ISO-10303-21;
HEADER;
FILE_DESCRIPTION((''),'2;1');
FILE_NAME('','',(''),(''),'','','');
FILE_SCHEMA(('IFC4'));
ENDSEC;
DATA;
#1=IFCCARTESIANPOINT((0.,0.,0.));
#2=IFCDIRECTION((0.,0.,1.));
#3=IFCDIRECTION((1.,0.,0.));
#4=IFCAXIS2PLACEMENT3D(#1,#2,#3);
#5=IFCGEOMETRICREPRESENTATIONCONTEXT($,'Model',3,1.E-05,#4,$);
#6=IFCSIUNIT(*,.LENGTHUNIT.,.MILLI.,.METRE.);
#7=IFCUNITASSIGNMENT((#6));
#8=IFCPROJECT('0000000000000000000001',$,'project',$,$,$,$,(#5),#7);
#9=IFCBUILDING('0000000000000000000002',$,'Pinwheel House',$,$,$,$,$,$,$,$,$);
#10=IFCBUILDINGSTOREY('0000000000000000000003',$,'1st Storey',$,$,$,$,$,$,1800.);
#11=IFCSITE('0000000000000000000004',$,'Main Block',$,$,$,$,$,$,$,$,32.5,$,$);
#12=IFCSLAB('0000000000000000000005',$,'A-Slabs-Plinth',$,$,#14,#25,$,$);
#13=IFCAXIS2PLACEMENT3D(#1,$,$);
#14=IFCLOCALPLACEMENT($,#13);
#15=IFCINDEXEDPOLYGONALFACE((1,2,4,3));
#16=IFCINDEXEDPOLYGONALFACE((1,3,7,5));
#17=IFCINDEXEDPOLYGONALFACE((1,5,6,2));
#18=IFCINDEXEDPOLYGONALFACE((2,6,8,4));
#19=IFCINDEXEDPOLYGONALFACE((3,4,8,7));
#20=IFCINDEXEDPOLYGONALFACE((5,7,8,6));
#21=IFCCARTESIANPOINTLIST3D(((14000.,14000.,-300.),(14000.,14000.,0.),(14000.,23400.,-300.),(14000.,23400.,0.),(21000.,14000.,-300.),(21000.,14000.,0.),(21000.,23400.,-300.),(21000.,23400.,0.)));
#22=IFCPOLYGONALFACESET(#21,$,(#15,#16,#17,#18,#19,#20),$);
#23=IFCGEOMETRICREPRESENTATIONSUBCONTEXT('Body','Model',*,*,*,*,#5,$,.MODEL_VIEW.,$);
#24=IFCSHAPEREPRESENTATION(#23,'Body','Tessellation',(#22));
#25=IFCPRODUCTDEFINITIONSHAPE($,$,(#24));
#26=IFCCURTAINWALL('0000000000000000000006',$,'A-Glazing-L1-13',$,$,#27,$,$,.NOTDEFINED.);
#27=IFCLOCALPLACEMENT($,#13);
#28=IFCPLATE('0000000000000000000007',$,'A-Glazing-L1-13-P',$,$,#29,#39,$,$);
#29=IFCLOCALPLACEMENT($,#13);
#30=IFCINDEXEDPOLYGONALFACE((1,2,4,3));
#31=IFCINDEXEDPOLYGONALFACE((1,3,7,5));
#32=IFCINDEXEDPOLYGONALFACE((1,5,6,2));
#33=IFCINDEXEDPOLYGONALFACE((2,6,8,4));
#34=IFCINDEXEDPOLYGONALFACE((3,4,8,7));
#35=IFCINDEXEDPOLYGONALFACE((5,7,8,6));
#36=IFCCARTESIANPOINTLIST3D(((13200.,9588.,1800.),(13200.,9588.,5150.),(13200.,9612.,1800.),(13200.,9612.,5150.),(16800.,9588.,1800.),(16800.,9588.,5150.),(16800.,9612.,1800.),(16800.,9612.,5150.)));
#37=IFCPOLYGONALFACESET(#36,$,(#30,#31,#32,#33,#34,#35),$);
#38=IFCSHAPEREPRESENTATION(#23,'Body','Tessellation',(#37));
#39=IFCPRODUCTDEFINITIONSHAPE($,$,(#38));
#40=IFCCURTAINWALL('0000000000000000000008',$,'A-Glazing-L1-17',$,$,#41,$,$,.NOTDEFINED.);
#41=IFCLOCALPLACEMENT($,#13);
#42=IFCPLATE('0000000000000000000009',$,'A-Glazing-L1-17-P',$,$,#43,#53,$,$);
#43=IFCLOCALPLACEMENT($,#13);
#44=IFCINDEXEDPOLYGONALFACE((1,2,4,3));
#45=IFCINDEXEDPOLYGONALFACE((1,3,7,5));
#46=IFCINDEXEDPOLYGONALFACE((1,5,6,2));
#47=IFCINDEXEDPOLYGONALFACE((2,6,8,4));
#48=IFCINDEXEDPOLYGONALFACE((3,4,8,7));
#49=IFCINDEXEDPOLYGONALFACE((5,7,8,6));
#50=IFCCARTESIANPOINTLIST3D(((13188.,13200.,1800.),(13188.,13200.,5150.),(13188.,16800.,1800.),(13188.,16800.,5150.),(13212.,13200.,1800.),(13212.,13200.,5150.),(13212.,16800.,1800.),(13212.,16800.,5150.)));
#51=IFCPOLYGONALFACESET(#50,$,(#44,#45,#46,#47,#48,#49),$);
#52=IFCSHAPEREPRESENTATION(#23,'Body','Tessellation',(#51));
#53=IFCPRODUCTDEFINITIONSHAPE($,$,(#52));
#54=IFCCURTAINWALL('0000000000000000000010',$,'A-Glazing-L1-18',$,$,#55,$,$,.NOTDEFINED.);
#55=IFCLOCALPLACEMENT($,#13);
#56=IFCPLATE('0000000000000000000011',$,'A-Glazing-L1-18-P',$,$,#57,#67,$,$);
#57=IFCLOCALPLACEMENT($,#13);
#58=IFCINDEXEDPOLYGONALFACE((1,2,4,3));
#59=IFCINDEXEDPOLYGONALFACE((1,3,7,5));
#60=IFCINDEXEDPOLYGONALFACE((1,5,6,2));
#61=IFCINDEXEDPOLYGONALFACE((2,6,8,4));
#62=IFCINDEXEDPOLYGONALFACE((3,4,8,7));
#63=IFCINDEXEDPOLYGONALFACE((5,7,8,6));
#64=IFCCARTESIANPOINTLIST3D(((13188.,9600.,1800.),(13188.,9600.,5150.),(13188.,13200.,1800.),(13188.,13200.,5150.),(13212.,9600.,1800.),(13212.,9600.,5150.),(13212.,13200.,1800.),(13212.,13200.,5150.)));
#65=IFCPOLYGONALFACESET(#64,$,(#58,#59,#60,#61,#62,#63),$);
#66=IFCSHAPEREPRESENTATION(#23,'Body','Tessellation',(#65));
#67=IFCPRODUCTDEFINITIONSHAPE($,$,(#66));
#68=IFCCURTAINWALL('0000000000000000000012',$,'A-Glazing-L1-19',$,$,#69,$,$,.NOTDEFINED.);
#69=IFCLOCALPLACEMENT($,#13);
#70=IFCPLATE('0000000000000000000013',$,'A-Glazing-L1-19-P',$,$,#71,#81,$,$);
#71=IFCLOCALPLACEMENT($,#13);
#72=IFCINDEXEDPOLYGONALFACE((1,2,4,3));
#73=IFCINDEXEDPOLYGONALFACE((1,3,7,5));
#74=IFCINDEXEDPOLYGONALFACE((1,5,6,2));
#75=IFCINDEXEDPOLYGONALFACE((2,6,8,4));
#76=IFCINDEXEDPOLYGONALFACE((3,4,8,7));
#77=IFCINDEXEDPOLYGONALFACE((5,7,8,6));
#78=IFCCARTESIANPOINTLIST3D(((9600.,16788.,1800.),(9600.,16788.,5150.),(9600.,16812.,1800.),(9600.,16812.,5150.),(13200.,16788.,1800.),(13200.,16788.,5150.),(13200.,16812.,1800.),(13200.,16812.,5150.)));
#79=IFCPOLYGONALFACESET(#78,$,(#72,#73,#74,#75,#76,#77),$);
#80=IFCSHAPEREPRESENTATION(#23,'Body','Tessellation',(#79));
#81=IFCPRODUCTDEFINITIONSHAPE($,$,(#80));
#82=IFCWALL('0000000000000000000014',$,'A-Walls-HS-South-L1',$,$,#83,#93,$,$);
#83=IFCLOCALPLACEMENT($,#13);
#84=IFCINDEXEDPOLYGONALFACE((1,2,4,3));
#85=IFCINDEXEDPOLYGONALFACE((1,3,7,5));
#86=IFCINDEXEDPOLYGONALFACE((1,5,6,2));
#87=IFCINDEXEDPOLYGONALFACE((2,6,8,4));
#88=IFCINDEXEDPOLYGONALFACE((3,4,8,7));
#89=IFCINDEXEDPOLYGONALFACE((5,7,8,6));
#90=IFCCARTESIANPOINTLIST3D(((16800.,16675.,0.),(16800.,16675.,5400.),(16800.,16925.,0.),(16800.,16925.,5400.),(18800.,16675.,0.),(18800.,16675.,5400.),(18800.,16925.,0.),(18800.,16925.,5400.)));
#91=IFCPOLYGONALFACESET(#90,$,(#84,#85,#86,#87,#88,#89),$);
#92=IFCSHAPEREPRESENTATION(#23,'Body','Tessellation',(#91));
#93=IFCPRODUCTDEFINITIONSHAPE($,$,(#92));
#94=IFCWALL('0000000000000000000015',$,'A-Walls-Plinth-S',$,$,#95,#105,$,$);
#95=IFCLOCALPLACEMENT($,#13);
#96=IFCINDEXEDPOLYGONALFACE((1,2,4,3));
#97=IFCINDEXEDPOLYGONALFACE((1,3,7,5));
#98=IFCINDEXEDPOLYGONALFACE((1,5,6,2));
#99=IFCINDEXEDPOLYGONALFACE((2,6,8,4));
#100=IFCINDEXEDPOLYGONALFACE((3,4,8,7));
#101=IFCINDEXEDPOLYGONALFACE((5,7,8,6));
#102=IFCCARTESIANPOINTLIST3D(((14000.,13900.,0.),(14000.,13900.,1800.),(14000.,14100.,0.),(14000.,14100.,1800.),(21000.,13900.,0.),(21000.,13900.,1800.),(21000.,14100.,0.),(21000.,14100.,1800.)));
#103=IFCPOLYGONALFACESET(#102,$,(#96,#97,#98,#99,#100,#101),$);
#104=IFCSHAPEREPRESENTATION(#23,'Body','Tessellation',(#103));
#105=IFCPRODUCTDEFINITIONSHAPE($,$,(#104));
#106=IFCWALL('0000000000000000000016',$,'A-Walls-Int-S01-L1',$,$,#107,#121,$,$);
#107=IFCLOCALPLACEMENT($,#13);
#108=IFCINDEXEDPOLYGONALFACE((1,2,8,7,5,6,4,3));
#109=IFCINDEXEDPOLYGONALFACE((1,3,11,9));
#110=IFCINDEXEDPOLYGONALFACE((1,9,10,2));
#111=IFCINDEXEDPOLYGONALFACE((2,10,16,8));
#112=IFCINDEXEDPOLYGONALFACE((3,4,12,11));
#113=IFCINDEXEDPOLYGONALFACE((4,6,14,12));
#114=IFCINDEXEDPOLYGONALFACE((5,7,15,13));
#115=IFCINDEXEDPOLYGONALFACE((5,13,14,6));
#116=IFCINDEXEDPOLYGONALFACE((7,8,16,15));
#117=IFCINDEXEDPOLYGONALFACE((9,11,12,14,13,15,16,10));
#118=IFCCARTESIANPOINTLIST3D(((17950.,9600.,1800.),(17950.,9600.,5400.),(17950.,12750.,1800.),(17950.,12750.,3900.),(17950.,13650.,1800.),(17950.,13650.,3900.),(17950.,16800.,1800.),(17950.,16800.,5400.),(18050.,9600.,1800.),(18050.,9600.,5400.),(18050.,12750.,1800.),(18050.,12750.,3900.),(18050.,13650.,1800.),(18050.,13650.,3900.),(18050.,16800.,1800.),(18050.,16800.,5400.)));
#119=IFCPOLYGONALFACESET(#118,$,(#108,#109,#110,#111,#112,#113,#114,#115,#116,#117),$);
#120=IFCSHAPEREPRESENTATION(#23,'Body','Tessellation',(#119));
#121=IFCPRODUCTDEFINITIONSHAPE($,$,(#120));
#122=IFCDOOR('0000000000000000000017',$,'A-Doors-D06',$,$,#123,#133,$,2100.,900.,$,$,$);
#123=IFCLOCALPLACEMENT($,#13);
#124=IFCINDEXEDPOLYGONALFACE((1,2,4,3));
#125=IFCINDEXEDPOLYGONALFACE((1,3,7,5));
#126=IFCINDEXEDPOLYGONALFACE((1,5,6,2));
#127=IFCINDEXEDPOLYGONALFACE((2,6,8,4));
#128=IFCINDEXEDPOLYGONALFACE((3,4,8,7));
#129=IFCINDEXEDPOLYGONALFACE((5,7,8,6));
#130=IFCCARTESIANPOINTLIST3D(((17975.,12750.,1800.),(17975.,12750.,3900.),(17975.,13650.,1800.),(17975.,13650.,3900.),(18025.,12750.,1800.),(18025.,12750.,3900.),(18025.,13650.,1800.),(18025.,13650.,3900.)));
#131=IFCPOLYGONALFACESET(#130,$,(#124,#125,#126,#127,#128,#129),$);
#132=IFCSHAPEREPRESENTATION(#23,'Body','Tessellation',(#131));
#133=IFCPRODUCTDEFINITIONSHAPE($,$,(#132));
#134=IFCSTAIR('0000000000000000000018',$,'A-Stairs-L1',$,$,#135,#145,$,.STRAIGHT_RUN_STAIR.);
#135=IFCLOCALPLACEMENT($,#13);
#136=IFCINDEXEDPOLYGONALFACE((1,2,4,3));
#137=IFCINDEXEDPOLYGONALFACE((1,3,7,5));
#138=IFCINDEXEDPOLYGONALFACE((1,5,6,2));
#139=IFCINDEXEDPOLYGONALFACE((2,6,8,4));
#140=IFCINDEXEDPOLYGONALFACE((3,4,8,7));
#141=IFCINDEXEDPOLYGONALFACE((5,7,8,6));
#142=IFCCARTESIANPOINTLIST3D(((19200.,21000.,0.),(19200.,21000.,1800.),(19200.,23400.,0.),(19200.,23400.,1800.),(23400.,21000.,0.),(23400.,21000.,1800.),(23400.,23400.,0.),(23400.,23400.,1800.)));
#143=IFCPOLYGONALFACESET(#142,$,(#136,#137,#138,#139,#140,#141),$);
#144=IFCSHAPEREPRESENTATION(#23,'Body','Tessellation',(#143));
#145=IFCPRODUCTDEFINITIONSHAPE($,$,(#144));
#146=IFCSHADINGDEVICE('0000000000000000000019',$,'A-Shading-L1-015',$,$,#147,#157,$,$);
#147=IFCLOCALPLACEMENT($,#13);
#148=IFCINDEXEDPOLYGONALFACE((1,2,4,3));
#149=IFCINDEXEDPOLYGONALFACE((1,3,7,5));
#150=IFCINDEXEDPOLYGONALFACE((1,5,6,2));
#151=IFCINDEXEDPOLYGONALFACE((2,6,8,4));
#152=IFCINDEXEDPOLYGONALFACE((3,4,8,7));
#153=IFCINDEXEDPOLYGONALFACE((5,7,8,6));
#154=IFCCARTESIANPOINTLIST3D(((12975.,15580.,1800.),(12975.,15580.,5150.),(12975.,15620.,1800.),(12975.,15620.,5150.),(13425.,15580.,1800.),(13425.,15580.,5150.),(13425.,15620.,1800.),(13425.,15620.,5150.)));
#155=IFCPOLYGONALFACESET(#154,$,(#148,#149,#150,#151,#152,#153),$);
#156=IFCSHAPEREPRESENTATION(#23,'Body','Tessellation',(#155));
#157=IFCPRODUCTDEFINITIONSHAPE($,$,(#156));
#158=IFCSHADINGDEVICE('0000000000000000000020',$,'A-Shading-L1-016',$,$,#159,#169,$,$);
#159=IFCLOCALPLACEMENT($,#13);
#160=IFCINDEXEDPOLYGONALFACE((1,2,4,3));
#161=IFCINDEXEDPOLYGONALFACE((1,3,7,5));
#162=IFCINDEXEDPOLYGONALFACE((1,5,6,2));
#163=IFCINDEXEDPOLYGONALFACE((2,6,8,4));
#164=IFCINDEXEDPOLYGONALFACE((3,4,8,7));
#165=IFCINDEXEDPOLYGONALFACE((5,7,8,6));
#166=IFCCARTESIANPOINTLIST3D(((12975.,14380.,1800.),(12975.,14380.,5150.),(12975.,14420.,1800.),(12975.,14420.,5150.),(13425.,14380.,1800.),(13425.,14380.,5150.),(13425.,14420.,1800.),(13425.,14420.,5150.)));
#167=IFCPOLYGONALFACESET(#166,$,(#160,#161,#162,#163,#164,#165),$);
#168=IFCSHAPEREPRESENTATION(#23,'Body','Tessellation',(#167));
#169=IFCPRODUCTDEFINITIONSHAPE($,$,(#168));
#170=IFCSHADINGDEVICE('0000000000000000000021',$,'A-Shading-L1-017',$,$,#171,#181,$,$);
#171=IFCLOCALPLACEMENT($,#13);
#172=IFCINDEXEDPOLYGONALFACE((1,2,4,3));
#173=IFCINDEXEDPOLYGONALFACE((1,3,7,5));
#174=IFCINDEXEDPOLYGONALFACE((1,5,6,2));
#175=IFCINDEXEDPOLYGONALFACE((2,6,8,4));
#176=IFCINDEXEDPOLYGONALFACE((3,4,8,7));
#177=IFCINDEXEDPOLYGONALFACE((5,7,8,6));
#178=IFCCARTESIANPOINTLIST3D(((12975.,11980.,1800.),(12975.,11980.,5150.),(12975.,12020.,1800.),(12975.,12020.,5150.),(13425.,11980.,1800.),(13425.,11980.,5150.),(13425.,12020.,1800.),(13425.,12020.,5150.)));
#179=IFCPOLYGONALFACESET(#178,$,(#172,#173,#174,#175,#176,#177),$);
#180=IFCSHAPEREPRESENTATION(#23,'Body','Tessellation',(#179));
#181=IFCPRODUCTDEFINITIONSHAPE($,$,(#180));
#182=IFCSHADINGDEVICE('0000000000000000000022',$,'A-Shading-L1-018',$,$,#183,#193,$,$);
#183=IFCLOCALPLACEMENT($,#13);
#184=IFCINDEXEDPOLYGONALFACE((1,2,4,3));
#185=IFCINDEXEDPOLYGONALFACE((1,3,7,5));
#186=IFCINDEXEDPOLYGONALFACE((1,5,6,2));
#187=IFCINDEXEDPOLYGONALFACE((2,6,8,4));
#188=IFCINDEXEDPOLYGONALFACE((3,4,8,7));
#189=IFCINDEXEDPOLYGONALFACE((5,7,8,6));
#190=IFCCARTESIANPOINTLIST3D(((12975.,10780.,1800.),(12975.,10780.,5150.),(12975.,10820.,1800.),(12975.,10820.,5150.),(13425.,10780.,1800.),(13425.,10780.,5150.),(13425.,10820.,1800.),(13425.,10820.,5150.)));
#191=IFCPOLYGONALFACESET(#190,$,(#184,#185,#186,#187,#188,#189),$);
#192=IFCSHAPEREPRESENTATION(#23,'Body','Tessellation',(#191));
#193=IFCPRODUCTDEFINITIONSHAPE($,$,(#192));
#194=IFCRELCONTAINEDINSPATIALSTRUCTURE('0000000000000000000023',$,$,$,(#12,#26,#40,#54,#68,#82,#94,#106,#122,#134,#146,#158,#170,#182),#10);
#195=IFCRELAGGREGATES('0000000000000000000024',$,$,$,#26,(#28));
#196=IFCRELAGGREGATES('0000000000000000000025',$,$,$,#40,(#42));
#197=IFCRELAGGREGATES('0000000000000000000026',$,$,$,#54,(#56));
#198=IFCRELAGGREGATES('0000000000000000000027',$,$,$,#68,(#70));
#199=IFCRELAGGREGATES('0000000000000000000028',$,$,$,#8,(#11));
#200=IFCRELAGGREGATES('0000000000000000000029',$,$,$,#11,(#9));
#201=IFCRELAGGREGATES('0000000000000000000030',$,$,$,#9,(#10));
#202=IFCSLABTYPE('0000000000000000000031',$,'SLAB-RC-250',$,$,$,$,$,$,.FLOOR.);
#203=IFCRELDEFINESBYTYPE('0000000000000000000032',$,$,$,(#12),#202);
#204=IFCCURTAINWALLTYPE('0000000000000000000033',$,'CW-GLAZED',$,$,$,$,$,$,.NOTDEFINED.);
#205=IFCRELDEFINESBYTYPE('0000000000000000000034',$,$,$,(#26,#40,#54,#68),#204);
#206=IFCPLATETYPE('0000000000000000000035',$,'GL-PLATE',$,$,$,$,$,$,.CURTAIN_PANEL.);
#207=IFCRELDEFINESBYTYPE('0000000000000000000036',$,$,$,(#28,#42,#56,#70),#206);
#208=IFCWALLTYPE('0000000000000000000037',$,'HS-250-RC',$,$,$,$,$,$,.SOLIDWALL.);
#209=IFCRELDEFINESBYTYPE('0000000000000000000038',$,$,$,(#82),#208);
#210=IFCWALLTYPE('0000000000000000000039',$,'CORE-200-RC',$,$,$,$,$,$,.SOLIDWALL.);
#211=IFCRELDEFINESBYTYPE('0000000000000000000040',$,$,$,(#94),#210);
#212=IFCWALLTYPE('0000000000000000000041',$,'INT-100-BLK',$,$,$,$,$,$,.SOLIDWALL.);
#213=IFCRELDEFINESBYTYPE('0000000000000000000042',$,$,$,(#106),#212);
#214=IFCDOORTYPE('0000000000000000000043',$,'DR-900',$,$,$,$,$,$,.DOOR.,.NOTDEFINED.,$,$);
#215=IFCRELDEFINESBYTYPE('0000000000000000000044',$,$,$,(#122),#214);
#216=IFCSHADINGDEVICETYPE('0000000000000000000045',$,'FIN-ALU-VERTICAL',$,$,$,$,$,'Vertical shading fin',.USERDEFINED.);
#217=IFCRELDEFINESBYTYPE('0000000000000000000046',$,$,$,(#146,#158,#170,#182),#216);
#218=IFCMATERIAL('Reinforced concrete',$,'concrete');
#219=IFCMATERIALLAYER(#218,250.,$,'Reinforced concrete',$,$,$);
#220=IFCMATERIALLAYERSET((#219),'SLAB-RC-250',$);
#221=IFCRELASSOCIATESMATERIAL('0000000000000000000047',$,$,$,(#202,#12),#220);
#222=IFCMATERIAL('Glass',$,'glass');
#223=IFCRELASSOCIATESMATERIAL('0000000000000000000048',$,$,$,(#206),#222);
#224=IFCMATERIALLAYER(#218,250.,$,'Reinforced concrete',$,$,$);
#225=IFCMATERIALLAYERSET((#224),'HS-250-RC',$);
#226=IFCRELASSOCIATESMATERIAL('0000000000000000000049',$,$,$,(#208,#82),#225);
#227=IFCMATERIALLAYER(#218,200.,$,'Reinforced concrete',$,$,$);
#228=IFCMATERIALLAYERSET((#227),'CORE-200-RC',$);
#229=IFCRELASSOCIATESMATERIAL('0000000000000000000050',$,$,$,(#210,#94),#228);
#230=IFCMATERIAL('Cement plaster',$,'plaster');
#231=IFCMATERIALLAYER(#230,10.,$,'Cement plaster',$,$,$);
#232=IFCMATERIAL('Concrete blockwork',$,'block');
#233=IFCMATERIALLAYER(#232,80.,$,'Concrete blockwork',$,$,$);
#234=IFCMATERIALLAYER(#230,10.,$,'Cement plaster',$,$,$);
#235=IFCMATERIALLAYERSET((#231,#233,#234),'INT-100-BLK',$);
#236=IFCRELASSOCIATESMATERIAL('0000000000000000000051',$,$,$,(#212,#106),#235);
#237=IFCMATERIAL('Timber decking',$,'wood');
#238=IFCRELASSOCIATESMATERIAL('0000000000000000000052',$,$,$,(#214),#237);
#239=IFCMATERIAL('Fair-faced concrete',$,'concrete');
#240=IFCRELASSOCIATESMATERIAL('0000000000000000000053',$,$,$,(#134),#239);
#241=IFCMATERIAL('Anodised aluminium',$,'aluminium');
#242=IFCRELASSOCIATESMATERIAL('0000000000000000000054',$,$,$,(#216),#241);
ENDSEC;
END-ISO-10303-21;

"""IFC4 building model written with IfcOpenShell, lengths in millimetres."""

from ifc_helpers import new_model, si_unit, frame, origin_with_axes, place, context, subcontext, project, spatial, indexed_curve, outline, extrude, material, layer, layer_set, layer_usage, type_object, element, fill, aggregate, save


model = new_model("IFC4")

# Units and contexts
model_context = context("Model", 3, precision=1e-05, world=origin_with_axes())
body_context = subcontext(model_context, "Body", "Model", "MODEL_VIEW")
ifc_project = project(units=[si_unit("LENGTHUNIT", "METRE", prefix="MILLI")], contexts=[model_context])

# Site, building, storey
site = spatial("IfcSite", under=ifc_project, Name="Main Block", RefElevation=32.5)
building = spatial("IfcBuilding", under=site, Name="Pinwheel House")
storey = spatial("IfcBuildingStorey", under=building, Name="1st Storey", Elevation=1800.0)

# Shared definitions
ifc_material_1 = material(Name="Anodised aluminium", Category="aluminium")

# Slab
ifc_material_2 = material(Name="Reinforced concrete", Category="concrete")
ifc_layer_1 = layer(ifc_material_2, 250.0, Name="Reinforced concrete")
ifc_layer_set_1 = layer_set([ifc_layer_1], Name="SLAB-RC-250")
slab_type = type_object("IfcSlabType", Name="SLAB-RC-250", PredefinedType="FLOOR", material=ifc_layer_set_1)
ifc_layer_usage_1 = layer_usage(ifc_layer_set_1, "AXIS3", "POSITIVE", 0.0)
slab_1_placement = place(None, frame((0.0, 0.0, -300.0), z_axis=(0.0, 0.0, 1.0), x_axis=(1.0, 0.0, 0.0)))
element("IfcSlab", 1, at=slab_1_placement, inside=storey, type_object=slab_type, material=ifc_layer_usage_1, Name="A-Slabs-Plinth", context=body_context, shape_type="SweptSolid", body=[
    extrude(outline(indexed_curve([(14000.0, 14000.0), (21000.0, 14000.0), (21000.0, 23400.0), (14000.0, 23400.0)])), None, (0.0, 0.0, 1.0), 300.0),
])

# Curtain walls, plates
curtain_wall_type = type_object("IfcCurtainWallType", Name="CW-GLAZED", PredefinedType="NOTDEFINED")
curtain_wall_1 = element("IfcCurtainWall", 2, inside=storey, type_object=curtain_wall_type, Name="A-Glazing-L1-13", PredefinedType="NOTDEFINED")
ifc_material_3 = material(Name="Glass", Category="glass")
plate_type = type_object("IfcPlateType", Name="GL-PLATE", PredefinedType="CURTAIN_PANEL", material=ifc_material_3)
plate_1_placement = place(None, frame((15000.0, 9600.0, 1800.0), z_axis=(0.0, 0.0, 1.0), x_axis=(1.0, 0.0, 0.0)))
plate_1 = element("IfcPlate", 3, at=plate_1_placement, type_object=plate_type, Name="A-Glazing-L1-13-P", context=body_context, shape_type="SweptSolid", body=[
    extrude(outline(indexed_curve([(-1800.0, -12.0), (1800.0, -12.0), (1800.0, 12.0), (-1800.0, 12.0)])), None, (0.0, 0.0, 1.0), 3350.0),
])
aggregate(curtain_wall_1, [plate_1])
curtain_wall_2 = element("IfcCurtainWall", 4, inside=storey, type_object=curtain_wall_type, Name="A-Glazing-L1-17", PredefinedType="NOTDEFINED")
plate_2_placement = place(None, frame((13200.0, 15000.0, 1800.0), z_axis=(0.0, 0.0, 1.0), x_axis=(0.0, -1.0, 0.0)))
plate_2 = element("IfcPlate", 5, at=plate_2_placement, type_object=plate_type, Name="A-Glazing-L1-17-P", context=body_context, shape_type="SweptSolid", body=[
    extrude(outline(indexed_curve([(-1800.0, -12.0), (1800.0, -12.0), (1800.0, 12.0), (-1800.0, 12.0)])), None, (0.0, 0.0, 1.0), 3350.0),
])
aggregate(curtain_wall_2, [plate_2])
curtain_wall_3 = element("IfcCurtainWall", 6, inside=storey, type_object=curtain_wall_type, Name="A-Glazing-L1-18", PredefinedType="NOTDEFINED")
plate_3_placement = place(None, frame((13200.0, 11400.0, 1800.0), z_axis=(0.0, 0.0, 1.0), x_axis=(0.0, -1.0, 0.0)))
plate_3 = element("IfcPlate", 7, at=plate_3_placement, type_object=plate_type, Name="A-Glazing-L1-18-P", context=body_context, shape_type="SweptSolid", body=[
    extrude(outline(indexed_curve([(-1800.0, -12.0), (1800.0, -12.0), (1800.0, 12.0), (-1800.0, 12.0)])), None, (0.0, 0.0, 1.0), 3350.0),
])
aggregate(curtain_wall_3, [plate_3])
curtain_wall_4 = element("IfcCurtainWall", 8, inside=storey, type_object=curtain_wall_type, Name="A-Glazing-L1-19", PredefinedType="NOTDEFINED")
plate_4_placement = place(None, frame((11400.0, 16800.0, 1800.0), z_axis=(0.0, 0.0, 1.0), x_axis=(1.0, 0.0, 0.0)))
plate_4 = element("IfcPlate", 9, at=plate_4_placement, type_object=plate_type, Name="A-Glazing-L1-19-P", context=body_context, shape_type="SweptSolid", body=[
    extrude(outline(indexed_curve([(-1800.0, -12.0), (1800.0, -12.0), (1800.0, 12.0), (-1800.0, 12.0)])), None, (0.0, 0.0, 1.0), 3350.0),
])
aggregate(curtain_wall_4, [plate_4])

# Walls
ifc_layer_2 = layer(ifc_material_2, 250.0, Name="Reinforced concrete")
ifc_layer_set_2 = layer_set([ifc_layer_2], Name="HS-250-RC")
ifc_layer_usage_2 = layer_usage(ifc_layer_set_2, "AXIS2", "POSITIVE", 0.0)
wall_type_1 = type_object("IfcWallType", Name="HS-250-RC", PredefinedType="SOLIDWALL", material=ifc_layer_set_2)
wall_1_placement = place(None, frame((16800.0, 16675.0, 0.0), z_axis=(0.0, 0.0, 1.0), x_axis=(1.0, 0.0, 0.0)))
element("IfcWall", 10, at=wall_1_placement, inside=storey, type_object=wall_type_1, material=ifc_layer_usage_2, Name="A-Walls-HS-South-L1", context=body_context, shape_type="SweptSolid", body=[
    extrude(outline(indexed_curve([(0.0, 0.0), (0.0, 250.0), (2000.0, 250.0), (2000.0, 0.0), (0.0, 0.0)], self_intersect=False)), origin_with_axes(), (0.0, 0.0, 1.0), 5400.0),
])
ifc_layer_3 = layer(ifc_material_2, 200.0, Name="Reinforced concrete")
ifc_layer_set_3 = layer_set([ifc_layer_3], Name="CORE-200-RC")
ifc_layer_usage_3 = layer_usage(ifc_layer_set_3, "AXIS2", "POSITIVE", 0.0)
wall_type_2 = type_object("IfcWallType", Name="CORE-200-RC", PredefinedType="SOLIDWALL", material=ifc_layer_set_3)
wall_2_placement = place(None, frame((14000.0, 13900.0, 0.0), z_axis=(0.0, 0.0, 1.0), x_axis=(1.0, 0.0, 0.0)))
element("IfcWall", 11, at=wall_2_placement, inside=storey, type_object=wall_type_2, material=ifc_layer_usage_3, Name="A-Walls-Plinth-S", context=body_context, shape_type="SweptSolid", body=[
    extrude(outline(indexed_curve([(0.0, 0.0), (0.0, 200.0), (7000.0, 200.0), (7000.0, 0.0), (0.0, 0.0)], self_intersect=False)), origin_with_axes(), (0.0, 0.0, 1.0), 1800.0),
])

# Wall, opening, door
ifc_material_4 = material(Name="Cement plaster", Category="plaster")
ifc_layer_4 = layer(ifc_material_4, 10.0, Name="Cement plaster")
ifc_material_5 = material(Name="Concrete blockwork", Category="block")
ifc_layer_5 = layer(ifc_material_5, 80.0, Name="Concrete blockwork")
ifc_layer_6 = layer(ifc_material_4, 10.0, Name="Cement plaster")
ifc_layer_set_4 = layer_set([ifc_layer_4, ifc_layer_5, ifc_layer_6], Name="INT-100-BLK")
ifc_layer_usage_4 = layer_usage(ifc_layer_set_4, "AXIS2", "POSITIVE", 0.0)
wall_type_3 = type_object("IfcWallType", Name="INT-100-BLK", PredefinedType="SOLIDWALL", material=ifc_layer_set_4)
wall_3_placement = place(None, frame((18050.0, 9600.0, 1800.0), z_axis=(0.0, 0.0, 1.0), x_axis=(0.0, 1.0, 0.0)))
wall_3 = element("IfcWall", 12, at=wall_3_placement, inside=storey, type_object=wall_type_3, material=ifc_layer_usage_4, Name="A-Walls-Int-S01-L1", context=body_context, shape_type="SweptSolid", body=[
    extrude(outline(indexed_curve([(0.0, 0.0), (0.0, 100.0), (7200.0, 100.0), (7200.0, 0.0), (0.0, 0.0)], self_intersect=False)), origin_with_axes(), (0.0, 0.0, 1.0), 3600.0),
])
opening_placement = place(wall_3_placement, frame((3600.0, 50.0, 0.0), z_axis=(0.0, 0.0, 1.0), x_axis=(1.0, 0.0, 0.0)))
opening = element("IfcOpeningElement", 13, at=opening_placement, cuts=wall_3, PredefinedType="OPENING", context=body_context, shape_type="SweptSolid", body=[
    extrude(outline(indexed_curve([(-450.0, -100.0), (450.0, -100.0), (450.0, 100.0), (-450.0, 100.0)])), None, (0.0, 0.0, 1.0), 2100.0),
])
ifc_material_6 = material(Name="Timber decking", Category="wood")
door_type = type_object("IfcDoorType", Name="DR-900", OperationType="NOTDEFINED", PredefinedType="DOOR", material=ifc_material_6)
door_placement = place(None, frame((18000.0, 13200.0, 1800.0), z_axis=(0.0, 0.0, 1.0), x_axis=(0.0, 1.0, 0.0)))
door = element("IfcDoor", 14, at=door_placement, inside=storey, type_object=door_type, Name="A-Doors-D06", OverallHeight=2100.0, OverallWidth=900.0, context=body_context, shape_type="SweptSolid", body=[
    extrude(outline(indexed_curve([(-450.0, -25.0), (450.0, -25.0), (450.0, 25.0), (-450.0, 25.0)])), None, (0.0, 0.0, 1.0), 2100.0),
])
fill(opening, door)

# Stair
ifc_material_7 = material(Name="Fair-faced concrete", Category="concrete")
stair_placement = place(None, origin_with_axes())
element("IfcStair", 15, at=stair_placement, inside=storey, material=ifc_material_7, Name="A-Stairs-L1", PredefinedType="STRAIGHT_RUN_STAIR", context=body_context, shape_type="SweptSolid", body=[
    extrude(outline(indexed_curve([(19200.0, 21000.0), (23400.0, 21000.0), (23400.0, 23400.0), (19200.0, 23400.0)])), None, (0.0, 0.0, 1.0), 1800.0),
])

# Shading devices
shading_device_type = type_object("IfcShadingDeviceType", Name="FIN-ALU-VERTICAL", ElementType="Vertical shading fin", PredefinedType="USERDEFINED", material=ifc_material_1)
for number, where, z_axis, x_axis, name in (
    (16, (13200.0, 15600.0, 1800.0), (0.0, 0.0, 1.0), (0.0, -1.0, 0.0), "A-Shading-L1-015"),
    (17, (13200.0, 14400.0, 1800.0), (0.0, 0.0, 1.0), (0.0, -1.0, 0.0), "A-Shading-L1-016"),
    (18, (13200.0, 12000.0, 1800.0), (0.0, 0.0, 1.0), (0.0, -1.0, 0.0), "A-Shading-L1-017"),
    (19, (13200.0, 10800.0, 1800.0), (0.0, 0.0, 1.0), (0.0, -1.0, 0.0), "A-Shading-L1-018"),
):
    element("IfcShadingDevice", number, at=place(None, frame(where, z_axis=z_axis, x_axis=x_axis)), inside=storey, type_object=shading_device_type, Name=name, context=body_context, shape_type="SweptSolid", body=[
        extrude(outline(indexed_curve([(-20.0, -225.0), (20.0, -225.0), (20.0, 225.0), (-20.0, 225.0)])), None, (0.0, 0.0, 1.0), 3350.0),
    ])

save(model, "model.ifc")
